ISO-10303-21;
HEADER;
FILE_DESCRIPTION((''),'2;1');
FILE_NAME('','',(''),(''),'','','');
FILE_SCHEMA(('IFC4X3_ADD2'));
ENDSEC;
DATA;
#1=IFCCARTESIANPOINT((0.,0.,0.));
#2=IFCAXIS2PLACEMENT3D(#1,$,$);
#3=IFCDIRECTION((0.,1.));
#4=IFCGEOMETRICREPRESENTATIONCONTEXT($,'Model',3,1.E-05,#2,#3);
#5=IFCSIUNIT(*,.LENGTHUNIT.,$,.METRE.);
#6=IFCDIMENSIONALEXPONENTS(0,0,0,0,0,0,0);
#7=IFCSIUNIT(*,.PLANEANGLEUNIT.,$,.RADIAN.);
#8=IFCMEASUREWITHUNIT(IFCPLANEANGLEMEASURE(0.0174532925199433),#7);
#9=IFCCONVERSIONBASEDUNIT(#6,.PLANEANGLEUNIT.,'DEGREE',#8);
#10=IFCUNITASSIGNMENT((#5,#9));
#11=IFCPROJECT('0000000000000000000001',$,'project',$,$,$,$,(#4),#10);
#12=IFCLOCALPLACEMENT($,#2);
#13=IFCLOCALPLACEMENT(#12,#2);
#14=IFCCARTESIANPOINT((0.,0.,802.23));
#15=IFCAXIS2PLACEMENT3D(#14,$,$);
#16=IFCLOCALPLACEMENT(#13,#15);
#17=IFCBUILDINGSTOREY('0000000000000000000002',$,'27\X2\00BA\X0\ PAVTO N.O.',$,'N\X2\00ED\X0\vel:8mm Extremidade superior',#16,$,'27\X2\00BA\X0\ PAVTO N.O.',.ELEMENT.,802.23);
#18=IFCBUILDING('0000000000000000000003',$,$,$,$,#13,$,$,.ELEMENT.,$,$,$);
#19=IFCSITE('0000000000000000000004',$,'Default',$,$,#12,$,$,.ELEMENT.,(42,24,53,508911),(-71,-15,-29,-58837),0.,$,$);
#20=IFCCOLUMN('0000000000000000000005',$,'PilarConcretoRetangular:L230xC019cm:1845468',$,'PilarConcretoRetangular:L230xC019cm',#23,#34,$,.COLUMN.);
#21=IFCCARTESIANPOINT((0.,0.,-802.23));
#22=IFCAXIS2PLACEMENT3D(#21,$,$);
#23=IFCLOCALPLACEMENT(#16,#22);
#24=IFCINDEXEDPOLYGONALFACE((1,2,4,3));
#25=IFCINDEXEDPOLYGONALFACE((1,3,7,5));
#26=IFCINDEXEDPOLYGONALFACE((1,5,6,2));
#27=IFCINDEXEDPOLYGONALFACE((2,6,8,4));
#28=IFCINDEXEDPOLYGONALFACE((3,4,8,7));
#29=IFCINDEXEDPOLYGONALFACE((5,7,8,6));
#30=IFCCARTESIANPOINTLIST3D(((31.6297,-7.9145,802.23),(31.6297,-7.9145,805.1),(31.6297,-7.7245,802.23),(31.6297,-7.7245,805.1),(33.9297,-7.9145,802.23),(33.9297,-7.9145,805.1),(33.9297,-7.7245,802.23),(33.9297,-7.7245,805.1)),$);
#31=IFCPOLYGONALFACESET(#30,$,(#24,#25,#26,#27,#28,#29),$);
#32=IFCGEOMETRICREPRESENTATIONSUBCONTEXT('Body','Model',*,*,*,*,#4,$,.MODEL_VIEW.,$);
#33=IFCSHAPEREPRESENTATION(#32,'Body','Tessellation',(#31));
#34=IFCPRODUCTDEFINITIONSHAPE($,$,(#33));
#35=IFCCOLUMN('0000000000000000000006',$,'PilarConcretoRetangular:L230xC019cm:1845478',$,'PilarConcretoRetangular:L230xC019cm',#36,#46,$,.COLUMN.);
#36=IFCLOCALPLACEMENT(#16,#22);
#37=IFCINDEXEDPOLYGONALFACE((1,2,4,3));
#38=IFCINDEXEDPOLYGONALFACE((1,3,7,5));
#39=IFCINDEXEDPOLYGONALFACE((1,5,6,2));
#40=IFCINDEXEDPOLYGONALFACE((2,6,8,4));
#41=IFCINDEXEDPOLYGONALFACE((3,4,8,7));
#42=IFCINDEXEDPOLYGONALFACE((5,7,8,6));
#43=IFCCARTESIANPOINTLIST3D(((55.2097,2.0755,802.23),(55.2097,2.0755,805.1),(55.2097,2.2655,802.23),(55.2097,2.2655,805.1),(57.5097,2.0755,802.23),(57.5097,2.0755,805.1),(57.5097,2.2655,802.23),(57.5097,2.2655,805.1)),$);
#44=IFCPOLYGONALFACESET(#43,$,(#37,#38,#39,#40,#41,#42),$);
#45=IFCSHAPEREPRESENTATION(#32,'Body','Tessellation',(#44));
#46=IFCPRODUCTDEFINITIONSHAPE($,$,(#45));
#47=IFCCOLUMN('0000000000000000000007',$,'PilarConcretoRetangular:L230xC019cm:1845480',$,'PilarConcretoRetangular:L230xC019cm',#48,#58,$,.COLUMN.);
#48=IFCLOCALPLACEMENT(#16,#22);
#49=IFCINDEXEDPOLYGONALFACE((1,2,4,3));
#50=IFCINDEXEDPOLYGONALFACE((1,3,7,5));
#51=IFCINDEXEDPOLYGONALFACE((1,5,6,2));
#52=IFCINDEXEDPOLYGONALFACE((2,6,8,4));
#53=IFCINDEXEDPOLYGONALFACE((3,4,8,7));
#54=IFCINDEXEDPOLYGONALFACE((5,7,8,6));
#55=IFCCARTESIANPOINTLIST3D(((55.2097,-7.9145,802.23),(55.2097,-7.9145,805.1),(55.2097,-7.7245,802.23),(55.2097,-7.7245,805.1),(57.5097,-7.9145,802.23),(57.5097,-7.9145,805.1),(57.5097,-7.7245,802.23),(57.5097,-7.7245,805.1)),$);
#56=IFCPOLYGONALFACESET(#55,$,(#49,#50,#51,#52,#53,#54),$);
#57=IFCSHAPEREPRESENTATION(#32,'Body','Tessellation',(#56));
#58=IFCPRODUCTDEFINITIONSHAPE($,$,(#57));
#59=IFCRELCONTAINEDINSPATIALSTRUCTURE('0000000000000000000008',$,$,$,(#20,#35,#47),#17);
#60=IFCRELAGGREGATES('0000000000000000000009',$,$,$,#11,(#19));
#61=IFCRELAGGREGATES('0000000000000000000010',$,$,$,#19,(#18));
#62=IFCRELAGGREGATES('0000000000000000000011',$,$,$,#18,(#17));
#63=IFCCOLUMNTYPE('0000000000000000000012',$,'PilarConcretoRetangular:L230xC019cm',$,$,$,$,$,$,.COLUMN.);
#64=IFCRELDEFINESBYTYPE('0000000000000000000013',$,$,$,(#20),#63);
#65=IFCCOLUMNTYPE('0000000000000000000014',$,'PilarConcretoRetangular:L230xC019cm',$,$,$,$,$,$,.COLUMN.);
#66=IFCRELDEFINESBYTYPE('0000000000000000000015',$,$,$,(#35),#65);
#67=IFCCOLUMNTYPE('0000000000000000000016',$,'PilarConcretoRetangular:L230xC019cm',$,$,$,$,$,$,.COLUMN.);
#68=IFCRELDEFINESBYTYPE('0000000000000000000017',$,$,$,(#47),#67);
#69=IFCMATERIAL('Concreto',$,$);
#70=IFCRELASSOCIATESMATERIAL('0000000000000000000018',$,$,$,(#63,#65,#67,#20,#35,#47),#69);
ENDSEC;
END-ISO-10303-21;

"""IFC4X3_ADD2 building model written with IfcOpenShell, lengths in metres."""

from ifc_helpers import new_model, entity, si_unit, converted_unit, direction, frame, frame_2d, origin, origin_2d_with_axis, place, context, subcontext, project, spatial, rectangle, extrude, source, transform, mapped, material, material_profile, profile_set, profile_usage, type_object, type_shapes, element, save


model = new_model("IFC4X3_ADD2")

# Units and contexts
model_context = context("Model", 3, precision=1e-05, world=origin(), true_north=direction((0.0, 1.0)))
body_context = subcontext(model_context, "Body", "Model", "MODEL_VIEW")
ifc_project = project(units=[si_unit("LENGTHUNIT", "METRE"), converted_unit("PLANEANGLEUNIT", "DEGREE", entity("IfcPlaneAngleMeasure", 0.0174532925199433), si_unit("PLANEANGLEUNIT", "RADIAN"), dimensions=[0, 0, 0, 0, 0, 0, 0])], contexts=[model_context])

# Site, building, storey
site_placement = place(None, origin())
site = spatial("IfcSite", under=ifc_project, at=site_placement, Name="Default", CompositionType="ELEMENT", RefLatitude=(42, 24, 53, 508911), RefLongitude=(-71, -15, -29, -58837), RefElevation=0.0)
building_placement = place(site_placement, origin())
building = spatial("IfcBuilding", under=site, at=building_placement, CompositionType="ELEMENT")
storey_placement = place(building_placement, frame((0.0, 0.0, 802.23)))
storey = spatial("IfcBuildingStorey", under=building, at=storey_placement, Name="27º PAVTO N.O.", ObjectType="Nível:8mm Extremidade superior", LongName="27º PAVTO N.O.", CompositionType="ELEMENT", Elevation=802.23)

# Columns
ifc_material = material(Name="Concreto")
ifc_material_profile_1 = material_profile(ifc_material, rectangle(XDim=2.3, YDim=0.19, at=frame_2d((0.192, 0.019), x_axis=(1.0, 0.0))), Name="L230xC019cm")
ifc_profile_set_1 = profile_set([ifc_material_profile_1], Name="L230xC019cm")
ifc_profile_usage_1 = profile_usage(ifc_profile_set_1)
column_type_1 = type_object("IfcColumnType", Name="PilarConcretoRetangular:L230xC019cm", PredefinedType="COLUMN", material=ifc_profile_set_1)
shared_shape_1 = source(origin(), body_context, "Body", "SweptSolid", [
    extrude(rectangle(XDim=2.3, YDim=0.19, at=frame_2d((0.0, 0.0), x_axis=(1.0, 0.0))), frame((32.7797, -7.8195, 802.23)), (0.0, 0.0, 1.0), 2.87),
])
type_shapes(column_type_1, [shared_shape_1])
column_1_placement = place(storey_placement, frame((0.0, 0.0, -802.23)))
element("IfcColumn", 1, at=column_1_placement, inside=storey, type_object=column_type_1, material=ifc_profile_usage_1, Name="PilarConcretoRetangular:L230xC019cm:1845468", ObjectType="PilarConcretoRetangular:L230xC019cm", PredefinedType="COLUMN", context=body_context, shape_type="MappedRepresentation", body=[
    mapped(shared_shape_1, transform((0.0, 0.0, 0.0), scale=1.0)),
])
column_type_2 = type_object("IfcColumnType", Name="PilarConcretoRetangular:L230xC019cm", PredefinedType="COLUMN", material=ifc_profile_set_1)
shared_shape_2 = source(origin(), body_context, "Body", "SweptSolid", [
    extrude(rectangle(XDim=2.3, YDim=0.19, at=origin_2d_with_axis()), frame((56.3597, 2.1705, 802.23), z_axis=(0.0, 0.0, 1.0), x_axis=(-1.0, 0.0, 0.0)), (0.0, 0.0, 1.0), 2.87),
])
type_shapes(column_type_2, [shared_shape_2])
column_2_placement = place(storey_placement, frame((0.0, 0.0, -802.23)))
element("IfcColumn", 2, at=column_2_placement, inside=storey, type_object=column_type_2, material=ifc_profile_usage_1, Name="PilarConcretoRetangular:L230xC019cm:1845478", ObjectType="PilarConcretoRetangular:L230xC019cm", PredefinedType="COLUMN", context=body_context, shape_type="MappedRepresentation", body=[
    mapped(shared_shape_2, transform((0.0, 0.0, 0.0), scale=1.0)),
])
column_type_3 = type_object("IfcColumnType", Name="PilarConcretoRetangular:L230xC019cm", PredefinedType="COLUMN", material=ifc_profile_set_1)
shared_shape_3 = source(origin(), body_context, "Body", "SweptSolid", [
    extrude(rectangle(XDim=2.3, YDim=0.19, at=origin_2d_with_axis()), frame((56.3597, -7.8195, 802.23), z_axis=(0.0, 0.0, 1.0), x_axis=(-1.0, 0.0, 0.0)), (0.0, 0.0, 1.0), 2.87),
])
type_shapes(column_type_3, [shared_shape_3])
column_3_placement = place(storey_placement, frame((0.0, 0.0, -802.23)))
element("IfcColumn", 3, at=column_3_placement, inside=storey, type_object=column_type_3, material=ifc_profile_usage_1, Name="PilarConcretoRetangular:L230xC019cm:1845480", ObjectType="PilarConcretoRetangular:L230xC019cm", PredefinedType="COLUMN", context=body_context, shape_type="MappedRepresentation", body=[
    mapped(shared_shape_3, transform((0.0, 0.0, 0.0), scale=1.0)),
])

save(model, "model.ifc")
